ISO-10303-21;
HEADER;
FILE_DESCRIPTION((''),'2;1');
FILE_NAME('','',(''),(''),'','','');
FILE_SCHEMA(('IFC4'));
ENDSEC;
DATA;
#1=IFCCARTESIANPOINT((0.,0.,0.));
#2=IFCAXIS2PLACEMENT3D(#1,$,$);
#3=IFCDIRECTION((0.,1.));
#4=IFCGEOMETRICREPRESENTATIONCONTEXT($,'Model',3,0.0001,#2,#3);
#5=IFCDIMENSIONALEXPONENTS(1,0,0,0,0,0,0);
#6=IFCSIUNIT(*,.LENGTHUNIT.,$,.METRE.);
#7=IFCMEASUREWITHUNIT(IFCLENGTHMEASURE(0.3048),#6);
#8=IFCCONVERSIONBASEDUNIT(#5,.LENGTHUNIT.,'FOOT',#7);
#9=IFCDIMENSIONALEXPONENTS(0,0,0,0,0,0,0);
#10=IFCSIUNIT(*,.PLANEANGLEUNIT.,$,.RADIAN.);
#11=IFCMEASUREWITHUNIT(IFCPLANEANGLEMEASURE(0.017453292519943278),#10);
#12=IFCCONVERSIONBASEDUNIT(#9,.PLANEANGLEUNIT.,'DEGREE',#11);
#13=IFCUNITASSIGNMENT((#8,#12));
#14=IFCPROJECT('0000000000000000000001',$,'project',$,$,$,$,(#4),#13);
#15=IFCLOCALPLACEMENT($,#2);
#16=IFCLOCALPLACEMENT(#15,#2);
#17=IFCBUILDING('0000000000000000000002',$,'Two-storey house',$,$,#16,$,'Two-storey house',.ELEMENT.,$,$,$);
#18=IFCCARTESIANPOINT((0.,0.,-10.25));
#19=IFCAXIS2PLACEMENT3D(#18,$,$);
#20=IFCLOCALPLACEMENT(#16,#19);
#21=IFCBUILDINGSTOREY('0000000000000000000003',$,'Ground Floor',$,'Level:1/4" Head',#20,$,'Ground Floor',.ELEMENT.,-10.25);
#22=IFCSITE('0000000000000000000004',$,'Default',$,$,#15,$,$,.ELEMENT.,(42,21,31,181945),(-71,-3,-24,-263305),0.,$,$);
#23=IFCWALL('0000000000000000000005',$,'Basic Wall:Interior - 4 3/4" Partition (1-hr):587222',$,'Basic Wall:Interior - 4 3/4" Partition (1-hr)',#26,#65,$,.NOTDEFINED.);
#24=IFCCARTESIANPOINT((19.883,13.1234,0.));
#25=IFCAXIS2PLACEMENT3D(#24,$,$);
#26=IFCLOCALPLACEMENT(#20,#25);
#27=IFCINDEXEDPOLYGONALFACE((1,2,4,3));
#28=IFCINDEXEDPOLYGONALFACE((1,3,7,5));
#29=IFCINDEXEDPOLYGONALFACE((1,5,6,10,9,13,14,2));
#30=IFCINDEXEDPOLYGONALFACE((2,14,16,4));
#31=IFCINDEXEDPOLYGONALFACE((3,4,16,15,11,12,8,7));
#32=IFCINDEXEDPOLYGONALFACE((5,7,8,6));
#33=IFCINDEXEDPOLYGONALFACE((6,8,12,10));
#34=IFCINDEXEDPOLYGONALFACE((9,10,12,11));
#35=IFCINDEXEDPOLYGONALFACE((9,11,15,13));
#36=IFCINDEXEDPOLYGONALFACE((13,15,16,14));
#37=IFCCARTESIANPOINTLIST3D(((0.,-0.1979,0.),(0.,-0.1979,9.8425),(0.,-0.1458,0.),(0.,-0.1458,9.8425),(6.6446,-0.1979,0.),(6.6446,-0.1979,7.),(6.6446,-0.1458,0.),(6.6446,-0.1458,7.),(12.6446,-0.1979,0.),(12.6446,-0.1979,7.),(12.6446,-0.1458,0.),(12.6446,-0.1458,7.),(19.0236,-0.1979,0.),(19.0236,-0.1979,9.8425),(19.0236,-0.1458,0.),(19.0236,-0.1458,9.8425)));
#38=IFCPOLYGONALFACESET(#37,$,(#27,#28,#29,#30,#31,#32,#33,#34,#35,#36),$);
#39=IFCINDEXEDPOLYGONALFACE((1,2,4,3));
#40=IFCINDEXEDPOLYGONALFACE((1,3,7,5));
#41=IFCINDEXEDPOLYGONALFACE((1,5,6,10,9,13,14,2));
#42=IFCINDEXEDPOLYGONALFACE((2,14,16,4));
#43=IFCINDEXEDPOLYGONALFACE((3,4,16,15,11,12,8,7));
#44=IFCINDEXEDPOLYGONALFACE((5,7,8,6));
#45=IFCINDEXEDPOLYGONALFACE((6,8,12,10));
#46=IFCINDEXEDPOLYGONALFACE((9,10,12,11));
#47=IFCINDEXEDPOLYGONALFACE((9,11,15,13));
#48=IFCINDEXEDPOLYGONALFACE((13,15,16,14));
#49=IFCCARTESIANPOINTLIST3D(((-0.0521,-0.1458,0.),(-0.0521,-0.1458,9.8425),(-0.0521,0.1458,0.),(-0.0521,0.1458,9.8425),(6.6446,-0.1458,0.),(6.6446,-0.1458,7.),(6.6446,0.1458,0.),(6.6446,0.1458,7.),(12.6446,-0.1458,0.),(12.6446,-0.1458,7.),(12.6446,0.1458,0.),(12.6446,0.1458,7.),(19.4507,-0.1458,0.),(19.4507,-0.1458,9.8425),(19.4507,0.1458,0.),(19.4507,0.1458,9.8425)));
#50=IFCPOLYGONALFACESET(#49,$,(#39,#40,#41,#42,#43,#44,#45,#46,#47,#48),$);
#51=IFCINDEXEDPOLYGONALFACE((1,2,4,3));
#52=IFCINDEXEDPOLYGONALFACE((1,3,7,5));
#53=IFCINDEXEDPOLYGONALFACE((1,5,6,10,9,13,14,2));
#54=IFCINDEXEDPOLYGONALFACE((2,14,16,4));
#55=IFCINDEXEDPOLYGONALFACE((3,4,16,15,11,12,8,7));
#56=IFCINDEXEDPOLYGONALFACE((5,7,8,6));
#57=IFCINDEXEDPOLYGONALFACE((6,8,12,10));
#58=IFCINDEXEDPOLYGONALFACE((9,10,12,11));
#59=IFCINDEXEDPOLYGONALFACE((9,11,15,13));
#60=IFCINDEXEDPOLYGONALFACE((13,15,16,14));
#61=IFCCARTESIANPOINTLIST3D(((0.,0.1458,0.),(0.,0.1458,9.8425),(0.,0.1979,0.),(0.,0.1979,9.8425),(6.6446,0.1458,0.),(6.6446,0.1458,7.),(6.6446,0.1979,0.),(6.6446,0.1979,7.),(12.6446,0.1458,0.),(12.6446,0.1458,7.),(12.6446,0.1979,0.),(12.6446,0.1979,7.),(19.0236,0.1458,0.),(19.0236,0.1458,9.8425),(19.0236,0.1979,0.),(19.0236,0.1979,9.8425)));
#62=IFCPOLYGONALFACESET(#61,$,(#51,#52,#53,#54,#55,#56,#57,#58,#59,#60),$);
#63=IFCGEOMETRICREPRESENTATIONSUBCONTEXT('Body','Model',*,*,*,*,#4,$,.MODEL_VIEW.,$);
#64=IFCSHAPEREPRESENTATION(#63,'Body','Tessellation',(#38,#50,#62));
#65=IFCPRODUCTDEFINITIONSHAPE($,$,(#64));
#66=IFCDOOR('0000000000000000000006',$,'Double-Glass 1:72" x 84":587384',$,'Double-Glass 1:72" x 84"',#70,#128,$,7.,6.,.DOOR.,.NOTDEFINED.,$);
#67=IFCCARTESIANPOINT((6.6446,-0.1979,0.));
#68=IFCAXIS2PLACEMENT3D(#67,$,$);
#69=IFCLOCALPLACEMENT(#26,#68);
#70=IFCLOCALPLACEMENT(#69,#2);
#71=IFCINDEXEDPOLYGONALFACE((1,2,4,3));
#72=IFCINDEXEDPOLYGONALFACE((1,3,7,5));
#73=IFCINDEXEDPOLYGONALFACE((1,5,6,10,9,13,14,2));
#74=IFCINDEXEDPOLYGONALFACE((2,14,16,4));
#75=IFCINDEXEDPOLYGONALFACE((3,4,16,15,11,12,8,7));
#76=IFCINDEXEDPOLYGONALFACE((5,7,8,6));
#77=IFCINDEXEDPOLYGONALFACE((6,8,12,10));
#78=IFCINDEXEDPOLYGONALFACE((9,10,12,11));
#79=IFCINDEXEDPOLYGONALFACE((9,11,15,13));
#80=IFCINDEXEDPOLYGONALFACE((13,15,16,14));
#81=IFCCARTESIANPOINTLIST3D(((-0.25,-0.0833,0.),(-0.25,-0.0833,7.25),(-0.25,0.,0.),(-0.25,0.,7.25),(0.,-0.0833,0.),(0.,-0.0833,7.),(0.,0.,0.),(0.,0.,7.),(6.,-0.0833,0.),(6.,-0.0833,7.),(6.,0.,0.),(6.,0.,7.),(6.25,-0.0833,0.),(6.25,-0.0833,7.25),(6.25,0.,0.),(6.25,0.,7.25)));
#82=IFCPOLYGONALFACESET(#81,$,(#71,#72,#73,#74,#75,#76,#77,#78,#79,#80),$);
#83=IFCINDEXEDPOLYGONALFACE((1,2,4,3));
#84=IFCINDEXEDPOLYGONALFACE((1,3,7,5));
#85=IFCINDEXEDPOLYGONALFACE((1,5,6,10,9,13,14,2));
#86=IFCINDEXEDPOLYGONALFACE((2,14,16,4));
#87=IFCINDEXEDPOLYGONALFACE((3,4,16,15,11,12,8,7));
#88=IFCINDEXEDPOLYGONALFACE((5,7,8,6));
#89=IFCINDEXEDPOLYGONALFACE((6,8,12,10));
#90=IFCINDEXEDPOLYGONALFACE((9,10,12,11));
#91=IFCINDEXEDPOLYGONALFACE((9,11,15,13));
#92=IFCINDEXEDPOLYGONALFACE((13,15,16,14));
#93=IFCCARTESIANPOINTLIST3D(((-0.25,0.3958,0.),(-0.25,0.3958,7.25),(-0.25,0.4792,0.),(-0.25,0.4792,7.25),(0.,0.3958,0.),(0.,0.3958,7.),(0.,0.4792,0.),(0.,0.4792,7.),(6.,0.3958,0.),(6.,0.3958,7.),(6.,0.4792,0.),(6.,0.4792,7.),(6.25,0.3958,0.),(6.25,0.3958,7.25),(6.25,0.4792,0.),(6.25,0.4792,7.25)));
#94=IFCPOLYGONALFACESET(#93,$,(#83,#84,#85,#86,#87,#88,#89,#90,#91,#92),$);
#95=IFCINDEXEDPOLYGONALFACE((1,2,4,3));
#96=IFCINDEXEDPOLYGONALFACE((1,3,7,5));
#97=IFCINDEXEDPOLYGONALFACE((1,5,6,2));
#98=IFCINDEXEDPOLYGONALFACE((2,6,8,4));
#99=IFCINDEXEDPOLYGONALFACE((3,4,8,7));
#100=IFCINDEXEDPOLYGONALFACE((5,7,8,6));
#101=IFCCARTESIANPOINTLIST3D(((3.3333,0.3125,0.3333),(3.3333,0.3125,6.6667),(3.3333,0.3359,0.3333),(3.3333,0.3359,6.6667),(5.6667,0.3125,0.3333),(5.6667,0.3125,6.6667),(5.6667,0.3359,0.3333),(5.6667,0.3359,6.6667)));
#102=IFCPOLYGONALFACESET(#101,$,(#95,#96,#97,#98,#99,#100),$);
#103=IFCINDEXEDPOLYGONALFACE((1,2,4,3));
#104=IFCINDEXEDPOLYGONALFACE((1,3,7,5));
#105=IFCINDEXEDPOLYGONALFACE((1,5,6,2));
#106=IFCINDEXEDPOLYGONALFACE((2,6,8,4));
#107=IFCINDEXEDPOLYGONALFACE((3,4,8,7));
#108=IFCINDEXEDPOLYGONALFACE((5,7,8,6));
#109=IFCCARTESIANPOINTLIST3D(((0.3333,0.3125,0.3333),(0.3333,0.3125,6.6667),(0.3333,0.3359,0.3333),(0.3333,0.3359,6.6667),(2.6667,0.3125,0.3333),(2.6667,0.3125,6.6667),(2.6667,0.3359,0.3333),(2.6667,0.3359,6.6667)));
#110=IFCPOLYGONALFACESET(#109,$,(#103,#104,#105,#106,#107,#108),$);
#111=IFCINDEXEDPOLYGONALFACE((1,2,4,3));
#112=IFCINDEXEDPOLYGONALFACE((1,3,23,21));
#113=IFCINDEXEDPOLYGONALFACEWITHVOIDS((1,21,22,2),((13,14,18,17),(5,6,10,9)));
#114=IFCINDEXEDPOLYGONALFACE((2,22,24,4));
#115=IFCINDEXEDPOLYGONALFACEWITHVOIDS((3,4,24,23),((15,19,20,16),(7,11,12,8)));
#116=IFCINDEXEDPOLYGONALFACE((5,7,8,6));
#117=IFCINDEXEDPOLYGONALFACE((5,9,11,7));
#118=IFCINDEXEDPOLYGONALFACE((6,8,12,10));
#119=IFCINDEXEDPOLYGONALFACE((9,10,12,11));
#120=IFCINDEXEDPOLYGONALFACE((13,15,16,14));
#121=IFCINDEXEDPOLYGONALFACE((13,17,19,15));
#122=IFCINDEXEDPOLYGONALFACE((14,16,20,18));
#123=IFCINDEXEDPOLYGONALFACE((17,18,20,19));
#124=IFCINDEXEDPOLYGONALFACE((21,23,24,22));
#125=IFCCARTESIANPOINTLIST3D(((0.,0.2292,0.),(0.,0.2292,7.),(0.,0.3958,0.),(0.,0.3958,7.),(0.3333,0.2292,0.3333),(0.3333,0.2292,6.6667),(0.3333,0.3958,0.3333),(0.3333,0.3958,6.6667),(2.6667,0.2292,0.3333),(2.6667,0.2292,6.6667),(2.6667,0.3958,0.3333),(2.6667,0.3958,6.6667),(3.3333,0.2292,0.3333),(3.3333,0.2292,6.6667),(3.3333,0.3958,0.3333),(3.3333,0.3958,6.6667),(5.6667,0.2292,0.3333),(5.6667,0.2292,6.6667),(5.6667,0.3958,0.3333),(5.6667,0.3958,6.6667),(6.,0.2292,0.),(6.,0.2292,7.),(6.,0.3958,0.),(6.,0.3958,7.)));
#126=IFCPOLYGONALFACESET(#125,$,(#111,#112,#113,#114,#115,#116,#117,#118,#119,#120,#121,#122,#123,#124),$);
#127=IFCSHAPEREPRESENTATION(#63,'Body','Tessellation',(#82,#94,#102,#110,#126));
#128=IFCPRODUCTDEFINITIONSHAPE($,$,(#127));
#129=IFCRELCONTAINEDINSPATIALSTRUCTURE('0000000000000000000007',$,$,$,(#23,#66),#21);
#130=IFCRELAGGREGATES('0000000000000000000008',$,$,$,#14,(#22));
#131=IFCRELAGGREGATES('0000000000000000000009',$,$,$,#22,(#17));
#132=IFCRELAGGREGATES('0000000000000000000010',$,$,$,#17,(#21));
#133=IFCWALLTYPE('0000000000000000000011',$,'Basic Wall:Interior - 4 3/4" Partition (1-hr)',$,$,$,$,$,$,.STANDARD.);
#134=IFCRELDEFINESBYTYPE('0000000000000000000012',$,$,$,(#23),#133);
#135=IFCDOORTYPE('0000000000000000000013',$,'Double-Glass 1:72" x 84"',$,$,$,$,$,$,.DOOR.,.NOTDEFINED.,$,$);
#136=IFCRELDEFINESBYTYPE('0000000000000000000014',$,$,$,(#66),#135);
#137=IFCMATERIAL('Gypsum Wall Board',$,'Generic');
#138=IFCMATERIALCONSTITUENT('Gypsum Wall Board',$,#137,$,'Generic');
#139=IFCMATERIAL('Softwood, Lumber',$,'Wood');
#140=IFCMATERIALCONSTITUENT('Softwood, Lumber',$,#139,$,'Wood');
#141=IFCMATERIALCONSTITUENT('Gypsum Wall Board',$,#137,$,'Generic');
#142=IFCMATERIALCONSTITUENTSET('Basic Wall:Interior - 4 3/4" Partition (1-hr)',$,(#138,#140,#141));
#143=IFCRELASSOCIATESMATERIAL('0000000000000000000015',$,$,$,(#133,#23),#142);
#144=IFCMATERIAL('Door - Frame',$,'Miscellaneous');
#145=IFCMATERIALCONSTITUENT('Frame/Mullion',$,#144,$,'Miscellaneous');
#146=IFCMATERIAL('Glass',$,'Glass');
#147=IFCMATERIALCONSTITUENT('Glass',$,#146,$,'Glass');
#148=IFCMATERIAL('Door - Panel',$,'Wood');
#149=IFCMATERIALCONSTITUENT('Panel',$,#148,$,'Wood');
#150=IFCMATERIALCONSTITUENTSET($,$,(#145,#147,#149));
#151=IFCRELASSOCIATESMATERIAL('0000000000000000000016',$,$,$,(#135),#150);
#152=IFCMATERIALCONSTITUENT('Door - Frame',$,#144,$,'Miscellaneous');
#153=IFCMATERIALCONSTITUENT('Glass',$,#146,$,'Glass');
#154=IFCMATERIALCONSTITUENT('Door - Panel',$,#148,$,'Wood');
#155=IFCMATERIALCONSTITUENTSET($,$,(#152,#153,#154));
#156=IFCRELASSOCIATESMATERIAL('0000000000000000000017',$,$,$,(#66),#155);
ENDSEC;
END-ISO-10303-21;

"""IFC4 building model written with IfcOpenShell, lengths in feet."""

from ifc_helpers import new_model, entity, si_unit, converted_unit, direction, frame, origin, place, context, subcontext, project, spatial, indexed_curve, outline, extrude, source, transform, mapped, material, constituent, constituent_set, type_object, type_shapes, element, fill, save


model = new_model("IFC4")

# Units and contexts
model_context = context("Model", 3, precision=0.0001, world=origin(), true_north=direction((0.0, 1.0)))
body_context = subcontext(model_context, "Body", "Model", "MODEL_VIEW")
ifc_project = project(units=[converted_unit("LENGTHUNIT", "FOOT", entity("IfcLengthMeasure", 0.3048), si_unit("LENGTHUNIT", "METRE"), dimensions=[1, 0, 0, 0, 0, 0, 0]), converted_unit("PLANEANGLEUNIT", "DEGREE", entity("IfcPlaneAngleMeasure", 0.017453292519943278), si_unit("PLANEANGLEUNIT", "RADIAN"), dimensions=[0, 0, 0, 0, 0, 0, 0])], contexts=[model_context])

# Site, building, storey
site_placement = place(None, origin())
site = spatial("IfcSite", under=ifc_project, at=site_placement, Name="Default", CompositionType="ELEMENT", RefLatitude=(42, 21, 31, 181945), RefLongitude=(-71, -3, -24, -263305), RefElevation=0.0)
building_placement = place(site_placement, origin())
building = spatial("IfcBuilding", under=site, at=building_placement, Name="Two-storey house", LongName="Two-storey house", CompositionType="ELEMENT")
storey_placement = place(building_placement, frame((0.0, 0.0, -10.25)))
storey = spatial("IfcBuildingStorey", under=building, at=storey_placement, Name="Ground Floor", ObjectType="Level:1/4\" Head", LongName="Ground Floor", CompositionType="ELEMENT", Elevation=-10.25)

# Shared definitions
ifc_material_1 = material(Name="Softwood, Lumber", Category="Wood")
ifc_material_2 = material(Name="Gypsum Wall Board", Category="Generic")
ifc_material_3 = material(Name="Door - Frame", Category="Miscellaneous")
ifc_material_4 = material(Name="Glass", Category="Glass")
ifc_material_5 = material(Name="Door - Panel", Category="Wood")

# Wall, opening, door
ifc_constituent_1 = constituent(ifc_material_2, Name="Gypsum Wall Board", Category="Generic")
ifc_constituent_2 = constituent(ifc_material_1, Name="Softwood, Lumber", Category="Wood")
ifc_constituent_3 = constituent(ifc_material_2, Name="Gypsum Wall Board", Category="Generic")
ifc_constituent_set_1 = constituent_set(constituents=[ifc_constituent_1, ifc_constituent_2, ifc_constituent_3], Name="Basic Wall:Interior - 4 3/4\" Partition (1-hr)")
wall_type_1 = type_object("IfcWallType", Name="Basic Wall:Interior - 4 3/4\" Partition (1-hr)", PredefinedType="STANDARD", material=ifc_constituent_set_1)
ifc_constituent_4 = constituent(ifc_material_3, Name="Frame/Mullion", Category="Miscellaneous")
ifc_constituent_5 = constituent(ifc_material_4, Name="Glass", Category="Glass")
ifc_constituent_6 = constituent(ifc_material_5, Name="Panel", Category="Wood")
ifc_constituent_set_2 = constituent_set(constituents=[ifc_constituent_4, ifc_constituent_5, ifc_constituent_6])
door_type_1 = type_object("IfcDoorType", Name="Double-Glass 1:72\" x 84\"", OperationType="NOTDEFINED", PredefinedType="DOOR", material=ifc_constituent_set_2)
shared_shape_1 = source(origin(), body_context, "Body", "SweptSolid", [
    extrude(outline(indexed_curve([(-3.25, -3.5625), (-3.0, -3.5625), (-3.0, 3.4375), (3.0, 3.4375), (3.0, -3.5625), (3.25, -3.5625), (3.25, 3.6875), (-3.25, 3.6875), (-3.25, -3.5625)], self_intersect=False)), frame((3.0, -0.0833, 3.5625), z_axis=(0.0, 1.0, 0.0), x_axis=(-1.0, 0.0, 0.0)), (0.0, 0.0, 1.0), 0.0833),
    extrude(outline(indexed_curve([(-3.0, -3.4375), (-3.0, 3.5625), (-3.25, 3.5625), (-3.25, -3.6875), (3.25, -3.6875), (3.25, 3.5625), (3.0, 3.5625), (3.0, -3.4375), (-3.0, -3.4375)], self_intersect=False)), frame((3.0, 0.3958, 3.5625), z_axis=(0.0, -1.0, 0.0), x_axis=(-1.0, 0.0, 0.0)), (0.0, 0.0, -1.0), 0.0833),
    extrude(outline(indexed_curve([(-0.0117, -1.1667), (0.0117, -1.1667), (0.0117, 1.1667), (-0.0117, 1.1667), (-0.0117, -1.1667)], self_intersect=False)), frame((4.5, 0.3242, 0.3333), z_axis=(0.0, 0.0, 1.0), x_axis=(0.0, 1.0, 0.0)), (0.0, 0.0, 1.0), 6.3333),
    extrude(outline(indexed_curve([(-0.0117, -1.1667), (0.0117, -1.1667), (0.0117, 1.1667), (-0.0117, 1.1667), (-0.0117, -1.1667)], self_intersect=False)), frame((1.5, 0.3242, 0.3333), z_axis=(0.0, 0.0, 1.0), x_axis=(0.0, 1.0, 0.0)), (0.0, 0.0, 1.0), 6.3333),
    extrude(outline(indexed_curve([(-3.5, -3.0), (3.5, -3.0), (3.5, 3.0), (-3.5, 3.0), (-3.5, -3.0)], self_intersect=False), holes=[indexed_curve([(-3.1667, 0.3333), (-3.1667, 2.6667), (3.1667, 2.6667), (3.1667, 0.3333), (-3.1667, 0.3333)], self_intersect=False), indexed_curve([(-3.1667, -2.6667), (-3.1667, -0.3333), (3.1667, -0.3333), (3.1667, -2.6667), (-3.1667, -2.6667)], self_intersect=False)]), frame((3.0, 0.2292, 3.5), z_axis=(0.0, 1.0, 0.0), x_axis=(0.0, 0.0, -1.0)), (0.0, 0.0, 1.0), 0.1667),
])
type_shapes(door_type_1, [shared_shape_1])
wall_1_placement = place(storey_placement, frame((19.883, 13.1234, 0.0)))
wall_1 = element("IfcWall", 1, at=wall_1_placement, inside=storey, type_object=wall_type_1, material=ifc_constituent_set_1, Name="Basic Wall:Interior - 4 3/4\" Partition (1-hr):587222", ObjectType="Basic Wall:Interior - 4 3/4\" Partition (1-hr)", PredefinedType="NOTDEFINED", context=body_context, shape_type="SweptSolid", body=[
    extrude(outline(indexed_curve([(-3.0664, -2.7894), (-3.0664, 4.2106), (-9.4454, 4.2106), (-9.4454, -5.6319), (9.5782, -5.6319), (9.5782, 4.2106), (2.9336, 4.2106), (2.9336, -2.7894), (-3.0664, -2.7894)], self_intersect=False)), frame((9.5782, -0.1979, 4.2106), z_axis=(0.0, -1.0, 0.0), x_axis=(-1.0, 0.0, 0.0)), (0.0, 0.0, -1.0), 0.0521),
    extrude(outline(indexed_curve([(-4.2106, -9.724), (5.6319, -9.724), (5.6319, 9.7787), (-4.2106, 9.7787), (-4.2106, 2.9727), (2.7894, 2.9727), (2.7894, -3.0273), (-4.2106, -3.0273), (-4.2106, -9.724)], self_intersect=False)), frame((9.6719, -0.1458, 4.2106), z_axis=(0.0, 1.0, 0.0), x_axis=(0.0, 0.0, 1.0)), (0.0, 0.0, 1.0), 0.2917),
    extrude(outline(indexed_curve([(-4.2106, -9.5782), (5.6319, -9.5782), (5.6319, 9.4454), (-4.2106, 9.4454), (-4.2106, 3.0664), (2.7894, 3.0664), (2.7894, -2.9336), (-4.2106, -2.9336), (-4.2106, -9.5782)], self_intersect=False)), frame((9.5782, 0.1458, 4.2106), z_axis=(0.0, 1.0, 0.0), x_axis=(0.0, 0.0, 1.0)), (0.0, 0.0, 1.0), 0.0521),
])
opening_1_placement = place(wall_1_placement, frame((6.6446, -0.1979, 0.0)))
opening_1 = element("IfcOpeningElement", 2, at=opening_1_placement, cuts=wall_1, PredefinedType="OPENING", context=body_context, shape_type="SweptSolid", body=[
    extrude(outline(indexed_curve([(0.0, 0.0), (7.0, 0.0), (7.0, 6.0), (0.0, 6.0), (0.0, 0.0)], self_intersect=False)), frame((0.0, 0.0, 0.0), z_axis=(0.0, 1.0, 0.0), x_axis=(0.0, 0.0, 1.0)), (0.0, 0.0, 1.0), 0.3958),
])
ifc_constituent_7 = constituent(ifc_material_3, Name="Door - Frame", Category="Miscellaneous")
ifc_constituent_8 = constituent(ifc_material_4, Name="Glass", Category="Glass")
ifc_constituent_9 = constituent(ifc_material_5, Name="Door - Panel", Category="Wood")
ifc_constituent_set_3 = constituent_set(constituents=[ifc_constituent_7, ifc_constituent_8, ifc_constituent_9])
door_1_placement = place(opening_1_placement, origin())
door_1 = element("IfcDoor", 3, at=door_1_placement, inside=storey, type_object=door_type_1, material=ifc_constituent_set_3, Name="Double-Glass 1:72\" x 84\":587384", ObjectType="Double-Glass 1:72\" x 84\"", OperationType="NOTDEFINED", OverallHeight=7.0, OverallWidth=6.0, PredefinedType="DOOR", context=body_context, shape_type="MappedRepresentation", body=[
    mapped(shared_shape_1, transform((0.0, 0.0, 0.0), scale=1.0)),
])
fill(opening_1, door_1)

save(model, "model.ifc")
